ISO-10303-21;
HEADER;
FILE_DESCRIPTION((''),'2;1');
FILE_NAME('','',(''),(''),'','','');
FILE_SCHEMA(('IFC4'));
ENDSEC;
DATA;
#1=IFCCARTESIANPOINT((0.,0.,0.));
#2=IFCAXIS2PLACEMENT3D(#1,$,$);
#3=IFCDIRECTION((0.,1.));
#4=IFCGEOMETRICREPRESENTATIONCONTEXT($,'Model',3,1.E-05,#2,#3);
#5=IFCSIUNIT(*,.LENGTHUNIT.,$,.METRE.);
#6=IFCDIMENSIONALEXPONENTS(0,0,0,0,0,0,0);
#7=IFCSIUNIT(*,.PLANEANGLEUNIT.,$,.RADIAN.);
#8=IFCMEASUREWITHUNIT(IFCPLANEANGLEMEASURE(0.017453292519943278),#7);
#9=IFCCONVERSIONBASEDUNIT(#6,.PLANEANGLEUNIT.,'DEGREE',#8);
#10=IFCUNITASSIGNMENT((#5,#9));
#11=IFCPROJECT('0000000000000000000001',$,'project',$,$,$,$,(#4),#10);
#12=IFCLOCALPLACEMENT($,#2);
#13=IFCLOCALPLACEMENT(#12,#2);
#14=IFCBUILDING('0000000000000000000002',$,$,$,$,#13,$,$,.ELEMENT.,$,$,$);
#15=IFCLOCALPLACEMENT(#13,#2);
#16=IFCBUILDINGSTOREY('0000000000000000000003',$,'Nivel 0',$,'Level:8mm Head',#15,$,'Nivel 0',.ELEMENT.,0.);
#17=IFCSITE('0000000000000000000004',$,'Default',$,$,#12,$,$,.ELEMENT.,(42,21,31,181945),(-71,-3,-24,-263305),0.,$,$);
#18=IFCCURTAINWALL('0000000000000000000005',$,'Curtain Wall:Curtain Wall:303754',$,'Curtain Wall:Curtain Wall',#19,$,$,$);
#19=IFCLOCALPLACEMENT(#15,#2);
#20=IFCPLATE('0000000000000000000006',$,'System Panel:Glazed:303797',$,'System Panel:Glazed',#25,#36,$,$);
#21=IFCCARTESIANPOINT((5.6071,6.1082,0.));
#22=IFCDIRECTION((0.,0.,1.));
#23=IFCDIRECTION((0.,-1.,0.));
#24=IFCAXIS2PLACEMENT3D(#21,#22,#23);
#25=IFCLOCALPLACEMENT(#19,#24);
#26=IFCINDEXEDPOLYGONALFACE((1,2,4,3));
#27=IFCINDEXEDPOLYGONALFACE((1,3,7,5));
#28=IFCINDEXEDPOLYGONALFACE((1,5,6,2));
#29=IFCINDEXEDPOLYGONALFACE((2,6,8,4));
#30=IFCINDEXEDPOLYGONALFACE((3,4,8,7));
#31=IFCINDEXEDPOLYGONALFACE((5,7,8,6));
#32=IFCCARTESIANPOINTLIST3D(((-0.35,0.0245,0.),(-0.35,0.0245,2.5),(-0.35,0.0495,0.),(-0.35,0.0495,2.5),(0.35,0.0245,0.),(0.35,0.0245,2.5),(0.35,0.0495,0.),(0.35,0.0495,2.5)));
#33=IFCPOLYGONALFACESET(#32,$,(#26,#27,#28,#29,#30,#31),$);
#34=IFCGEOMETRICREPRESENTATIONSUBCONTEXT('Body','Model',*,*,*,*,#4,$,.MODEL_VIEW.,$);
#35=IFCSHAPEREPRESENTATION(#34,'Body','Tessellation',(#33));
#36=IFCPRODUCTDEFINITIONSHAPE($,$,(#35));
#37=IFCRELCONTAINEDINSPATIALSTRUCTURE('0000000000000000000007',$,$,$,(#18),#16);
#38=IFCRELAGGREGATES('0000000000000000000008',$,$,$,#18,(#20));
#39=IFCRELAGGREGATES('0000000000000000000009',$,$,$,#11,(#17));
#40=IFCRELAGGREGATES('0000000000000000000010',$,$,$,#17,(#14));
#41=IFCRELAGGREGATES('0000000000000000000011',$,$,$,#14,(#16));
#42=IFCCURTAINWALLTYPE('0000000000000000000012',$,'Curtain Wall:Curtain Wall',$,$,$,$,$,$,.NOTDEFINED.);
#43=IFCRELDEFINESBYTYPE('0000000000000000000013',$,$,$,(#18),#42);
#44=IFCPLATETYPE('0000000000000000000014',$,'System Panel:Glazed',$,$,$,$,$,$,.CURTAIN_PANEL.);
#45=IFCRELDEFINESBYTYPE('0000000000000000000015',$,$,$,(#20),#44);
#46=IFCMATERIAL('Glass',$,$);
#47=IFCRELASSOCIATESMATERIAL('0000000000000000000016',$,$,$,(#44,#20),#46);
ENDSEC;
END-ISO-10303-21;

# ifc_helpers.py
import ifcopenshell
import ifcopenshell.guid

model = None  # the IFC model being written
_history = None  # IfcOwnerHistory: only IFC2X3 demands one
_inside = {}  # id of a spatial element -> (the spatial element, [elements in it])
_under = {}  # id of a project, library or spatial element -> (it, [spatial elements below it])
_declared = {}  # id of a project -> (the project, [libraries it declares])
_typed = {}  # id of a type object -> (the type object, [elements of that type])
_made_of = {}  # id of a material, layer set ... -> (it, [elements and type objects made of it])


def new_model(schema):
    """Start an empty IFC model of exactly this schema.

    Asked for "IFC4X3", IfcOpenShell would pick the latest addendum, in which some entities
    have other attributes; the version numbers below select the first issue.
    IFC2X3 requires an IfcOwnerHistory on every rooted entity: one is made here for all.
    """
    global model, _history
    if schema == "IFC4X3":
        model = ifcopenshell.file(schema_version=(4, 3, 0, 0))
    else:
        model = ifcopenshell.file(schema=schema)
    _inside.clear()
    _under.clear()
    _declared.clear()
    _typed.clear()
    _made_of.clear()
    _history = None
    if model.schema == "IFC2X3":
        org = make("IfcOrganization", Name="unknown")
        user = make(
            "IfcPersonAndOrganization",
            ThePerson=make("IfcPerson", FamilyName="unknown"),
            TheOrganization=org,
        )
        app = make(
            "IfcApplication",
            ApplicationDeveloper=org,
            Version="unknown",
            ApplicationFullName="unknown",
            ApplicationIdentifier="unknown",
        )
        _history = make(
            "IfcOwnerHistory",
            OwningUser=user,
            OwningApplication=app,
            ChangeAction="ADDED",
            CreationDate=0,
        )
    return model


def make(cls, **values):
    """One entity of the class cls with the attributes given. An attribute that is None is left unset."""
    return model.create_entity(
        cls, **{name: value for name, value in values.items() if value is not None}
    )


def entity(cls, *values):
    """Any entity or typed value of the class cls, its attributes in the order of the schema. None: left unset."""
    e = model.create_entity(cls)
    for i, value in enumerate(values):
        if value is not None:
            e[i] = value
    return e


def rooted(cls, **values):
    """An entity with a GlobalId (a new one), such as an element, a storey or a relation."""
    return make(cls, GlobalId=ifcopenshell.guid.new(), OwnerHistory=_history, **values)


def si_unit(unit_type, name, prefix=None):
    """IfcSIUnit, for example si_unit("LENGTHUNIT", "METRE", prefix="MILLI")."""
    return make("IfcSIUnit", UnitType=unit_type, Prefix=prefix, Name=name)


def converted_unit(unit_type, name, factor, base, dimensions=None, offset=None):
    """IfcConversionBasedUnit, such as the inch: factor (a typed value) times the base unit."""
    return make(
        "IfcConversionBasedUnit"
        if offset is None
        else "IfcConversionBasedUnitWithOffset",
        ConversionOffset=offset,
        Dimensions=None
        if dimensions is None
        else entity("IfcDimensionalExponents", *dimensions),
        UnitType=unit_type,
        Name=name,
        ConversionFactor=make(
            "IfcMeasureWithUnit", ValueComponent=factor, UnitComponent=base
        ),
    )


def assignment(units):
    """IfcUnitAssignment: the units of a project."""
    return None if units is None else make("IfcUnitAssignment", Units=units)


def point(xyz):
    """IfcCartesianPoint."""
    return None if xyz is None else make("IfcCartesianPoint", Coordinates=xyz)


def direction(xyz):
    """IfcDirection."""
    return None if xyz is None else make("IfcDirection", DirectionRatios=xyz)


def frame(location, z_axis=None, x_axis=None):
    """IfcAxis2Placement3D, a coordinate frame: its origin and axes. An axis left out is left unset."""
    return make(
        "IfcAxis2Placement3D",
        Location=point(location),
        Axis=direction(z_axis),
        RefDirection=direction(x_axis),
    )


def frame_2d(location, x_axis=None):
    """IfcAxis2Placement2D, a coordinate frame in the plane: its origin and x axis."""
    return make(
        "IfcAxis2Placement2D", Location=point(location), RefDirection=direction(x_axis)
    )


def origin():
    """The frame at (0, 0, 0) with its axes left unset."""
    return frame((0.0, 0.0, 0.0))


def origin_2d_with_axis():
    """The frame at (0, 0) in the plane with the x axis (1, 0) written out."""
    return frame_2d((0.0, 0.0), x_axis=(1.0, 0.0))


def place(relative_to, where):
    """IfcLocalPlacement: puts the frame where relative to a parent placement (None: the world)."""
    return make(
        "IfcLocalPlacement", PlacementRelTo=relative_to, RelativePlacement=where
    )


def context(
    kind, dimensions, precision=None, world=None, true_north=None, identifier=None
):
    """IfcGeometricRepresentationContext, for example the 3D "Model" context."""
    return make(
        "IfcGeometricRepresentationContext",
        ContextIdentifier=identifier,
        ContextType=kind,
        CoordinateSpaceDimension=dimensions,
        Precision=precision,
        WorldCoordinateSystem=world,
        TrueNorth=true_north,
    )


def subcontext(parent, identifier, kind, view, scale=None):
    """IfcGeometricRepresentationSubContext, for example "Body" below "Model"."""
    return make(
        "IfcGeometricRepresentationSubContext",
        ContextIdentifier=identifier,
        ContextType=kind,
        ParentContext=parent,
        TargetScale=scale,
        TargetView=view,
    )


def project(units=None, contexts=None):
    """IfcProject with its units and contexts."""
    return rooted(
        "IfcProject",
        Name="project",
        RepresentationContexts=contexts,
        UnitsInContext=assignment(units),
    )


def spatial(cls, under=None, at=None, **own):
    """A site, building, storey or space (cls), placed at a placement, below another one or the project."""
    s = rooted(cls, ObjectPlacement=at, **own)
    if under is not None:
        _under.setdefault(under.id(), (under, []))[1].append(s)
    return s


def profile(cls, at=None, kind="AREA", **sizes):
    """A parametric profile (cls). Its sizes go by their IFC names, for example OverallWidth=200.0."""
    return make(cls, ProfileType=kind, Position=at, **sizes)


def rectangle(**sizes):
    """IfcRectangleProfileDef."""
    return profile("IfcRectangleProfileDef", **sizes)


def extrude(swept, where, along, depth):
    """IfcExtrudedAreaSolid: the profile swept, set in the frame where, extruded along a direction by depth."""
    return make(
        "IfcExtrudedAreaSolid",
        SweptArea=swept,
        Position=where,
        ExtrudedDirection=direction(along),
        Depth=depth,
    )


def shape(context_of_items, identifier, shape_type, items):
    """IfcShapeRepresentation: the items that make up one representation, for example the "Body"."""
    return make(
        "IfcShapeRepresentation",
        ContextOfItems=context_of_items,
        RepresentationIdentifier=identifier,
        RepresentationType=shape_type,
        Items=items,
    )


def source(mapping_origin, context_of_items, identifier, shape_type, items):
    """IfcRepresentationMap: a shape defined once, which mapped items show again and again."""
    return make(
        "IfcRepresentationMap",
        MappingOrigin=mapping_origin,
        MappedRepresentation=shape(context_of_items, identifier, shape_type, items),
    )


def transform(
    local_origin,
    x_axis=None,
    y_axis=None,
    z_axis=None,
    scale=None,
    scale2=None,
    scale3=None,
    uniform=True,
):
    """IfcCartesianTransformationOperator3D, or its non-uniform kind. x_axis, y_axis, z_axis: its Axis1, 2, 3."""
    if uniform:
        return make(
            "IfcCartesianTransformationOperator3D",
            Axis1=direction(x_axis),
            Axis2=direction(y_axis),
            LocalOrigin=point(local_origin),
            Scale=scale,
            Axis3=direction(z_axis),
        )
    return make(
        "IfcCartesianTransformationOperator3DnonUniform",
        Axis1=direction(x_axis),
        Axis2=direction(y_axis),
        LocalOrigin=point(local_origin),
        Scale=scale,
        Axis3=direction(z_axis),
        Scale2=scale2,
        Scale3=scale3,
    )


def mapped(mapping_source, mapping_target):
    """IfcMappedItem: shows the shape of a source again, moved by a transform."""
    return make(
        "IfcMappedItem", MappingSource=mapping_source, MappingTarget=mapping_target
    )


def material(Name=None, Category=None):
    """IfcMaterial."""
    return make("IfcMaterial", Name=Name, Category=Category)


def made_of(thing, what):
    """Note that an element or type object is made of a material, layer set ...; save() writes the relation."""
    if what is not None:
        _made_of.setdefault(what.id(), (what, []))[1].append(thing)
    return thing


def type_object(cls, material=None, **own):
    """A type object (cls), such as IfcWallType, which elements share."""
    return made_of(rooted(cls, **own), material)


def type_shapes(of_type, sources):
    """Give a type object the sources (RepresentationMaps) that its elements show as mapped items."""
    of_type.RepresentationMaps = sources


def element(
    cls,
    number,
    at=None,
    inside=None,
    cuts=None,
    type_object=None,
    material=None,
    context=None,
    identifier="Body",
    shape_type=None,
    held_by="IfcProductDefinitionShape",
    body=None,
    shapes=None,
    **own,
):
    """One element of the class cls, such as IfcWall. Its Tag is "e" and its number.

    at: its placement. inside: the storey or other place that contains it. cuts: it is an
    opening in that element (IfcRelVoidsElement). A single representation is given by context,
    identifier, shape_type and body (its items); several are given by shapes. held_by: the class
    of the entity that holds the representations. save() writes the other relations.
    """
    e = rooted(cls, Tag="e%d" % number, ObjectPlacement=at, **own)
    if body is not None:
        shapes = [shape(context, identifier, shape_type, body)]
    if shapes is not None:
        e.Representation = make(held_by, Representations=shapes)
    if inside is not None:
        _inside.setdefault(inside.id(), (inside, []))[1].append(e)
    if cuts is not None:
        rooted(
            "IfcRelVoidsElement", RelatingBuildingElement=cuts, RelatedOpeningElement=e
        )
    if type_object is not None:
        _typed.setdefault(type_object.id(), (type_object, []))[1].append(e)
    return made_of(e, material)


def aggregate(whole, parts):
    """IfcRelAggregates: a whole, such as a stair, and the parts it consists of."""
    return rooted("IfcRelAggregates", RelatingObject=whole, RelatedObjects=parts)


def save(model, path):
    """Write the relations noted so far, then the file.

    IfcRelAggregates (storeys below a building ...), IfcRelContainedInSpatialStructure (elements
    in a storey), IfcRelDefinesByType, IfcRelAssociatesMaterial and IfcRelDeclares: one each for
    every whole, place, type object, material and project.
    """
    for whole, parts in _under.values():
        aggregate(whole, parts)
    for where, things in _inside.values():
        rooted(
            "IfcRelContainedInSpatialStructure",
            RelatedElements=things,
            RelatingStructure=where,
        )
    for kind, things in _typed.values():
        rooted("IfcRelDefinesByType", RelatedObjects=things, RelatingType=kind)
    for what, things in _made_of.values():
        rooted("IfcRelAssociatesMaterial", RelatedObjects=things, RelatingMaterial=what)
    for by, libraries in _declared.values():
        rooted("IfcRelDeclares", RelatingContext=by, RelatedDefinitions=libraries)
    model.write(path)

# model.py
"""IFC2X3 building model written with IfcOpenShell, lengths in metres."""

from ifc_helpers import new_model, entity, si_unit, converted_unit, direction, frame, origin, origin_2d_with_axis, place, context, subcontext, project, spatial, rectangle, extrude, source, transform, mapped, material, type_object, type_shapes, element, aggregate, save


model = new_model("IFC2X3")

# Units and contexts
model_context = context("Model", 3, precision=1e-05, world=origin(), true_north=direction((0.0, 1.0)))
body_context = subcontext(model_context, "Body", "Model", "MODEL_VIEW")
ifc_project = project(units=[si_unit("LENGTHUNIT", "METRE"), converted_unit("PLANEANGLEUNIT", "DEGREE", entity("IfcPlaneAngleMeasure", 0.017453292519943278), si_unit("PLANEANGLEUNIT", "RADIAN"), dimensions=[0, 0, 0, 0, 0, 0, 0])], contexts=[model_context])

# Site, building, storey
site_placement = place(None, origin())
site = spatial("IfcSite", under=ifc_project, at=site_placement, Name="Default", CompositionType="ELEMENT", RefLatitude=(42, 21, 31, 181945), RefLongitude=(-71, -3, -24, -263305), RefElevation=0.0)
building_placement = place(site_placement, origin())
building = spatial("IfcBuilding", under=site, at=building_placement, CompositionType="ELEMENT")
storey_placement = place(building_placement, origin())
storey = spatial("IfcBuildingStorey", under=building, at=storey_placement, Name="Nivel 0", ObjectType="Level:8mm Head", LongName="Nivel 0", CompositionType="ELEMENT", Elevation=0.0)

# Curtain wall, plate
curtain_wall_type = type_object("IfcCurtainWallType", Name="Curtain Wall:Curtain Wall", PredefinedType="NOTDEFINED")
curtain_wall_placement = place(storey_placement, origin())
curtain_wall = element("IfcCurtainWall", 1, at=curtain_wall_placement, inside=storey, type_object=curtain_wall_type, Name="Curtain Wall:Curtain Wall:303754", ObjectType="Curtain Wall:Curtain Wall")
ifc_material_1 = material(Name="Glass")
plate_type = type_object("IfcPlateType", Name="System Panel:Glazed", PredefinedType="CURTAIN_PANEL", material=ifc_material_1)
shared_shape_1 = source(origin(), body_context, "Body", "SweptSolid", [
    extrude(rectangle(XDim=0.025, YDim=0.7, at=origin_2d_with_axis()), frame((0.0, 0.037, 0.0), z_axis=(0.0, 0.0, 1.0), x_axis=(0.0, 1.0, 0.0)), (0.0, 0.0, 1.0), 2.5),
])
type_shapes(plate_type, [shared_shape_1])
plate_placement = place(curtain_wall_placement, frame((5.6071, 6.1082, 0.0), z_axis=(0.0, 0.0, 1.0), x_axis=(0.0, -1.0, 0.0)))
plate = element("IfcPlate", 2, at=plate_placement, type_object=plate_type, material=ifc_material_1, Name="System Panel:Glazed:303797", ObjectType="System Panel:Glazed", context=body_context, shape_type="MappedRepresentation", body=[
    mapped(shared_shape_1, transform((0.0, 0.0, 0.0), scale=1.0)),
])
aggregate(curtain_wall, [plate])

save(model, "model.ifc")
